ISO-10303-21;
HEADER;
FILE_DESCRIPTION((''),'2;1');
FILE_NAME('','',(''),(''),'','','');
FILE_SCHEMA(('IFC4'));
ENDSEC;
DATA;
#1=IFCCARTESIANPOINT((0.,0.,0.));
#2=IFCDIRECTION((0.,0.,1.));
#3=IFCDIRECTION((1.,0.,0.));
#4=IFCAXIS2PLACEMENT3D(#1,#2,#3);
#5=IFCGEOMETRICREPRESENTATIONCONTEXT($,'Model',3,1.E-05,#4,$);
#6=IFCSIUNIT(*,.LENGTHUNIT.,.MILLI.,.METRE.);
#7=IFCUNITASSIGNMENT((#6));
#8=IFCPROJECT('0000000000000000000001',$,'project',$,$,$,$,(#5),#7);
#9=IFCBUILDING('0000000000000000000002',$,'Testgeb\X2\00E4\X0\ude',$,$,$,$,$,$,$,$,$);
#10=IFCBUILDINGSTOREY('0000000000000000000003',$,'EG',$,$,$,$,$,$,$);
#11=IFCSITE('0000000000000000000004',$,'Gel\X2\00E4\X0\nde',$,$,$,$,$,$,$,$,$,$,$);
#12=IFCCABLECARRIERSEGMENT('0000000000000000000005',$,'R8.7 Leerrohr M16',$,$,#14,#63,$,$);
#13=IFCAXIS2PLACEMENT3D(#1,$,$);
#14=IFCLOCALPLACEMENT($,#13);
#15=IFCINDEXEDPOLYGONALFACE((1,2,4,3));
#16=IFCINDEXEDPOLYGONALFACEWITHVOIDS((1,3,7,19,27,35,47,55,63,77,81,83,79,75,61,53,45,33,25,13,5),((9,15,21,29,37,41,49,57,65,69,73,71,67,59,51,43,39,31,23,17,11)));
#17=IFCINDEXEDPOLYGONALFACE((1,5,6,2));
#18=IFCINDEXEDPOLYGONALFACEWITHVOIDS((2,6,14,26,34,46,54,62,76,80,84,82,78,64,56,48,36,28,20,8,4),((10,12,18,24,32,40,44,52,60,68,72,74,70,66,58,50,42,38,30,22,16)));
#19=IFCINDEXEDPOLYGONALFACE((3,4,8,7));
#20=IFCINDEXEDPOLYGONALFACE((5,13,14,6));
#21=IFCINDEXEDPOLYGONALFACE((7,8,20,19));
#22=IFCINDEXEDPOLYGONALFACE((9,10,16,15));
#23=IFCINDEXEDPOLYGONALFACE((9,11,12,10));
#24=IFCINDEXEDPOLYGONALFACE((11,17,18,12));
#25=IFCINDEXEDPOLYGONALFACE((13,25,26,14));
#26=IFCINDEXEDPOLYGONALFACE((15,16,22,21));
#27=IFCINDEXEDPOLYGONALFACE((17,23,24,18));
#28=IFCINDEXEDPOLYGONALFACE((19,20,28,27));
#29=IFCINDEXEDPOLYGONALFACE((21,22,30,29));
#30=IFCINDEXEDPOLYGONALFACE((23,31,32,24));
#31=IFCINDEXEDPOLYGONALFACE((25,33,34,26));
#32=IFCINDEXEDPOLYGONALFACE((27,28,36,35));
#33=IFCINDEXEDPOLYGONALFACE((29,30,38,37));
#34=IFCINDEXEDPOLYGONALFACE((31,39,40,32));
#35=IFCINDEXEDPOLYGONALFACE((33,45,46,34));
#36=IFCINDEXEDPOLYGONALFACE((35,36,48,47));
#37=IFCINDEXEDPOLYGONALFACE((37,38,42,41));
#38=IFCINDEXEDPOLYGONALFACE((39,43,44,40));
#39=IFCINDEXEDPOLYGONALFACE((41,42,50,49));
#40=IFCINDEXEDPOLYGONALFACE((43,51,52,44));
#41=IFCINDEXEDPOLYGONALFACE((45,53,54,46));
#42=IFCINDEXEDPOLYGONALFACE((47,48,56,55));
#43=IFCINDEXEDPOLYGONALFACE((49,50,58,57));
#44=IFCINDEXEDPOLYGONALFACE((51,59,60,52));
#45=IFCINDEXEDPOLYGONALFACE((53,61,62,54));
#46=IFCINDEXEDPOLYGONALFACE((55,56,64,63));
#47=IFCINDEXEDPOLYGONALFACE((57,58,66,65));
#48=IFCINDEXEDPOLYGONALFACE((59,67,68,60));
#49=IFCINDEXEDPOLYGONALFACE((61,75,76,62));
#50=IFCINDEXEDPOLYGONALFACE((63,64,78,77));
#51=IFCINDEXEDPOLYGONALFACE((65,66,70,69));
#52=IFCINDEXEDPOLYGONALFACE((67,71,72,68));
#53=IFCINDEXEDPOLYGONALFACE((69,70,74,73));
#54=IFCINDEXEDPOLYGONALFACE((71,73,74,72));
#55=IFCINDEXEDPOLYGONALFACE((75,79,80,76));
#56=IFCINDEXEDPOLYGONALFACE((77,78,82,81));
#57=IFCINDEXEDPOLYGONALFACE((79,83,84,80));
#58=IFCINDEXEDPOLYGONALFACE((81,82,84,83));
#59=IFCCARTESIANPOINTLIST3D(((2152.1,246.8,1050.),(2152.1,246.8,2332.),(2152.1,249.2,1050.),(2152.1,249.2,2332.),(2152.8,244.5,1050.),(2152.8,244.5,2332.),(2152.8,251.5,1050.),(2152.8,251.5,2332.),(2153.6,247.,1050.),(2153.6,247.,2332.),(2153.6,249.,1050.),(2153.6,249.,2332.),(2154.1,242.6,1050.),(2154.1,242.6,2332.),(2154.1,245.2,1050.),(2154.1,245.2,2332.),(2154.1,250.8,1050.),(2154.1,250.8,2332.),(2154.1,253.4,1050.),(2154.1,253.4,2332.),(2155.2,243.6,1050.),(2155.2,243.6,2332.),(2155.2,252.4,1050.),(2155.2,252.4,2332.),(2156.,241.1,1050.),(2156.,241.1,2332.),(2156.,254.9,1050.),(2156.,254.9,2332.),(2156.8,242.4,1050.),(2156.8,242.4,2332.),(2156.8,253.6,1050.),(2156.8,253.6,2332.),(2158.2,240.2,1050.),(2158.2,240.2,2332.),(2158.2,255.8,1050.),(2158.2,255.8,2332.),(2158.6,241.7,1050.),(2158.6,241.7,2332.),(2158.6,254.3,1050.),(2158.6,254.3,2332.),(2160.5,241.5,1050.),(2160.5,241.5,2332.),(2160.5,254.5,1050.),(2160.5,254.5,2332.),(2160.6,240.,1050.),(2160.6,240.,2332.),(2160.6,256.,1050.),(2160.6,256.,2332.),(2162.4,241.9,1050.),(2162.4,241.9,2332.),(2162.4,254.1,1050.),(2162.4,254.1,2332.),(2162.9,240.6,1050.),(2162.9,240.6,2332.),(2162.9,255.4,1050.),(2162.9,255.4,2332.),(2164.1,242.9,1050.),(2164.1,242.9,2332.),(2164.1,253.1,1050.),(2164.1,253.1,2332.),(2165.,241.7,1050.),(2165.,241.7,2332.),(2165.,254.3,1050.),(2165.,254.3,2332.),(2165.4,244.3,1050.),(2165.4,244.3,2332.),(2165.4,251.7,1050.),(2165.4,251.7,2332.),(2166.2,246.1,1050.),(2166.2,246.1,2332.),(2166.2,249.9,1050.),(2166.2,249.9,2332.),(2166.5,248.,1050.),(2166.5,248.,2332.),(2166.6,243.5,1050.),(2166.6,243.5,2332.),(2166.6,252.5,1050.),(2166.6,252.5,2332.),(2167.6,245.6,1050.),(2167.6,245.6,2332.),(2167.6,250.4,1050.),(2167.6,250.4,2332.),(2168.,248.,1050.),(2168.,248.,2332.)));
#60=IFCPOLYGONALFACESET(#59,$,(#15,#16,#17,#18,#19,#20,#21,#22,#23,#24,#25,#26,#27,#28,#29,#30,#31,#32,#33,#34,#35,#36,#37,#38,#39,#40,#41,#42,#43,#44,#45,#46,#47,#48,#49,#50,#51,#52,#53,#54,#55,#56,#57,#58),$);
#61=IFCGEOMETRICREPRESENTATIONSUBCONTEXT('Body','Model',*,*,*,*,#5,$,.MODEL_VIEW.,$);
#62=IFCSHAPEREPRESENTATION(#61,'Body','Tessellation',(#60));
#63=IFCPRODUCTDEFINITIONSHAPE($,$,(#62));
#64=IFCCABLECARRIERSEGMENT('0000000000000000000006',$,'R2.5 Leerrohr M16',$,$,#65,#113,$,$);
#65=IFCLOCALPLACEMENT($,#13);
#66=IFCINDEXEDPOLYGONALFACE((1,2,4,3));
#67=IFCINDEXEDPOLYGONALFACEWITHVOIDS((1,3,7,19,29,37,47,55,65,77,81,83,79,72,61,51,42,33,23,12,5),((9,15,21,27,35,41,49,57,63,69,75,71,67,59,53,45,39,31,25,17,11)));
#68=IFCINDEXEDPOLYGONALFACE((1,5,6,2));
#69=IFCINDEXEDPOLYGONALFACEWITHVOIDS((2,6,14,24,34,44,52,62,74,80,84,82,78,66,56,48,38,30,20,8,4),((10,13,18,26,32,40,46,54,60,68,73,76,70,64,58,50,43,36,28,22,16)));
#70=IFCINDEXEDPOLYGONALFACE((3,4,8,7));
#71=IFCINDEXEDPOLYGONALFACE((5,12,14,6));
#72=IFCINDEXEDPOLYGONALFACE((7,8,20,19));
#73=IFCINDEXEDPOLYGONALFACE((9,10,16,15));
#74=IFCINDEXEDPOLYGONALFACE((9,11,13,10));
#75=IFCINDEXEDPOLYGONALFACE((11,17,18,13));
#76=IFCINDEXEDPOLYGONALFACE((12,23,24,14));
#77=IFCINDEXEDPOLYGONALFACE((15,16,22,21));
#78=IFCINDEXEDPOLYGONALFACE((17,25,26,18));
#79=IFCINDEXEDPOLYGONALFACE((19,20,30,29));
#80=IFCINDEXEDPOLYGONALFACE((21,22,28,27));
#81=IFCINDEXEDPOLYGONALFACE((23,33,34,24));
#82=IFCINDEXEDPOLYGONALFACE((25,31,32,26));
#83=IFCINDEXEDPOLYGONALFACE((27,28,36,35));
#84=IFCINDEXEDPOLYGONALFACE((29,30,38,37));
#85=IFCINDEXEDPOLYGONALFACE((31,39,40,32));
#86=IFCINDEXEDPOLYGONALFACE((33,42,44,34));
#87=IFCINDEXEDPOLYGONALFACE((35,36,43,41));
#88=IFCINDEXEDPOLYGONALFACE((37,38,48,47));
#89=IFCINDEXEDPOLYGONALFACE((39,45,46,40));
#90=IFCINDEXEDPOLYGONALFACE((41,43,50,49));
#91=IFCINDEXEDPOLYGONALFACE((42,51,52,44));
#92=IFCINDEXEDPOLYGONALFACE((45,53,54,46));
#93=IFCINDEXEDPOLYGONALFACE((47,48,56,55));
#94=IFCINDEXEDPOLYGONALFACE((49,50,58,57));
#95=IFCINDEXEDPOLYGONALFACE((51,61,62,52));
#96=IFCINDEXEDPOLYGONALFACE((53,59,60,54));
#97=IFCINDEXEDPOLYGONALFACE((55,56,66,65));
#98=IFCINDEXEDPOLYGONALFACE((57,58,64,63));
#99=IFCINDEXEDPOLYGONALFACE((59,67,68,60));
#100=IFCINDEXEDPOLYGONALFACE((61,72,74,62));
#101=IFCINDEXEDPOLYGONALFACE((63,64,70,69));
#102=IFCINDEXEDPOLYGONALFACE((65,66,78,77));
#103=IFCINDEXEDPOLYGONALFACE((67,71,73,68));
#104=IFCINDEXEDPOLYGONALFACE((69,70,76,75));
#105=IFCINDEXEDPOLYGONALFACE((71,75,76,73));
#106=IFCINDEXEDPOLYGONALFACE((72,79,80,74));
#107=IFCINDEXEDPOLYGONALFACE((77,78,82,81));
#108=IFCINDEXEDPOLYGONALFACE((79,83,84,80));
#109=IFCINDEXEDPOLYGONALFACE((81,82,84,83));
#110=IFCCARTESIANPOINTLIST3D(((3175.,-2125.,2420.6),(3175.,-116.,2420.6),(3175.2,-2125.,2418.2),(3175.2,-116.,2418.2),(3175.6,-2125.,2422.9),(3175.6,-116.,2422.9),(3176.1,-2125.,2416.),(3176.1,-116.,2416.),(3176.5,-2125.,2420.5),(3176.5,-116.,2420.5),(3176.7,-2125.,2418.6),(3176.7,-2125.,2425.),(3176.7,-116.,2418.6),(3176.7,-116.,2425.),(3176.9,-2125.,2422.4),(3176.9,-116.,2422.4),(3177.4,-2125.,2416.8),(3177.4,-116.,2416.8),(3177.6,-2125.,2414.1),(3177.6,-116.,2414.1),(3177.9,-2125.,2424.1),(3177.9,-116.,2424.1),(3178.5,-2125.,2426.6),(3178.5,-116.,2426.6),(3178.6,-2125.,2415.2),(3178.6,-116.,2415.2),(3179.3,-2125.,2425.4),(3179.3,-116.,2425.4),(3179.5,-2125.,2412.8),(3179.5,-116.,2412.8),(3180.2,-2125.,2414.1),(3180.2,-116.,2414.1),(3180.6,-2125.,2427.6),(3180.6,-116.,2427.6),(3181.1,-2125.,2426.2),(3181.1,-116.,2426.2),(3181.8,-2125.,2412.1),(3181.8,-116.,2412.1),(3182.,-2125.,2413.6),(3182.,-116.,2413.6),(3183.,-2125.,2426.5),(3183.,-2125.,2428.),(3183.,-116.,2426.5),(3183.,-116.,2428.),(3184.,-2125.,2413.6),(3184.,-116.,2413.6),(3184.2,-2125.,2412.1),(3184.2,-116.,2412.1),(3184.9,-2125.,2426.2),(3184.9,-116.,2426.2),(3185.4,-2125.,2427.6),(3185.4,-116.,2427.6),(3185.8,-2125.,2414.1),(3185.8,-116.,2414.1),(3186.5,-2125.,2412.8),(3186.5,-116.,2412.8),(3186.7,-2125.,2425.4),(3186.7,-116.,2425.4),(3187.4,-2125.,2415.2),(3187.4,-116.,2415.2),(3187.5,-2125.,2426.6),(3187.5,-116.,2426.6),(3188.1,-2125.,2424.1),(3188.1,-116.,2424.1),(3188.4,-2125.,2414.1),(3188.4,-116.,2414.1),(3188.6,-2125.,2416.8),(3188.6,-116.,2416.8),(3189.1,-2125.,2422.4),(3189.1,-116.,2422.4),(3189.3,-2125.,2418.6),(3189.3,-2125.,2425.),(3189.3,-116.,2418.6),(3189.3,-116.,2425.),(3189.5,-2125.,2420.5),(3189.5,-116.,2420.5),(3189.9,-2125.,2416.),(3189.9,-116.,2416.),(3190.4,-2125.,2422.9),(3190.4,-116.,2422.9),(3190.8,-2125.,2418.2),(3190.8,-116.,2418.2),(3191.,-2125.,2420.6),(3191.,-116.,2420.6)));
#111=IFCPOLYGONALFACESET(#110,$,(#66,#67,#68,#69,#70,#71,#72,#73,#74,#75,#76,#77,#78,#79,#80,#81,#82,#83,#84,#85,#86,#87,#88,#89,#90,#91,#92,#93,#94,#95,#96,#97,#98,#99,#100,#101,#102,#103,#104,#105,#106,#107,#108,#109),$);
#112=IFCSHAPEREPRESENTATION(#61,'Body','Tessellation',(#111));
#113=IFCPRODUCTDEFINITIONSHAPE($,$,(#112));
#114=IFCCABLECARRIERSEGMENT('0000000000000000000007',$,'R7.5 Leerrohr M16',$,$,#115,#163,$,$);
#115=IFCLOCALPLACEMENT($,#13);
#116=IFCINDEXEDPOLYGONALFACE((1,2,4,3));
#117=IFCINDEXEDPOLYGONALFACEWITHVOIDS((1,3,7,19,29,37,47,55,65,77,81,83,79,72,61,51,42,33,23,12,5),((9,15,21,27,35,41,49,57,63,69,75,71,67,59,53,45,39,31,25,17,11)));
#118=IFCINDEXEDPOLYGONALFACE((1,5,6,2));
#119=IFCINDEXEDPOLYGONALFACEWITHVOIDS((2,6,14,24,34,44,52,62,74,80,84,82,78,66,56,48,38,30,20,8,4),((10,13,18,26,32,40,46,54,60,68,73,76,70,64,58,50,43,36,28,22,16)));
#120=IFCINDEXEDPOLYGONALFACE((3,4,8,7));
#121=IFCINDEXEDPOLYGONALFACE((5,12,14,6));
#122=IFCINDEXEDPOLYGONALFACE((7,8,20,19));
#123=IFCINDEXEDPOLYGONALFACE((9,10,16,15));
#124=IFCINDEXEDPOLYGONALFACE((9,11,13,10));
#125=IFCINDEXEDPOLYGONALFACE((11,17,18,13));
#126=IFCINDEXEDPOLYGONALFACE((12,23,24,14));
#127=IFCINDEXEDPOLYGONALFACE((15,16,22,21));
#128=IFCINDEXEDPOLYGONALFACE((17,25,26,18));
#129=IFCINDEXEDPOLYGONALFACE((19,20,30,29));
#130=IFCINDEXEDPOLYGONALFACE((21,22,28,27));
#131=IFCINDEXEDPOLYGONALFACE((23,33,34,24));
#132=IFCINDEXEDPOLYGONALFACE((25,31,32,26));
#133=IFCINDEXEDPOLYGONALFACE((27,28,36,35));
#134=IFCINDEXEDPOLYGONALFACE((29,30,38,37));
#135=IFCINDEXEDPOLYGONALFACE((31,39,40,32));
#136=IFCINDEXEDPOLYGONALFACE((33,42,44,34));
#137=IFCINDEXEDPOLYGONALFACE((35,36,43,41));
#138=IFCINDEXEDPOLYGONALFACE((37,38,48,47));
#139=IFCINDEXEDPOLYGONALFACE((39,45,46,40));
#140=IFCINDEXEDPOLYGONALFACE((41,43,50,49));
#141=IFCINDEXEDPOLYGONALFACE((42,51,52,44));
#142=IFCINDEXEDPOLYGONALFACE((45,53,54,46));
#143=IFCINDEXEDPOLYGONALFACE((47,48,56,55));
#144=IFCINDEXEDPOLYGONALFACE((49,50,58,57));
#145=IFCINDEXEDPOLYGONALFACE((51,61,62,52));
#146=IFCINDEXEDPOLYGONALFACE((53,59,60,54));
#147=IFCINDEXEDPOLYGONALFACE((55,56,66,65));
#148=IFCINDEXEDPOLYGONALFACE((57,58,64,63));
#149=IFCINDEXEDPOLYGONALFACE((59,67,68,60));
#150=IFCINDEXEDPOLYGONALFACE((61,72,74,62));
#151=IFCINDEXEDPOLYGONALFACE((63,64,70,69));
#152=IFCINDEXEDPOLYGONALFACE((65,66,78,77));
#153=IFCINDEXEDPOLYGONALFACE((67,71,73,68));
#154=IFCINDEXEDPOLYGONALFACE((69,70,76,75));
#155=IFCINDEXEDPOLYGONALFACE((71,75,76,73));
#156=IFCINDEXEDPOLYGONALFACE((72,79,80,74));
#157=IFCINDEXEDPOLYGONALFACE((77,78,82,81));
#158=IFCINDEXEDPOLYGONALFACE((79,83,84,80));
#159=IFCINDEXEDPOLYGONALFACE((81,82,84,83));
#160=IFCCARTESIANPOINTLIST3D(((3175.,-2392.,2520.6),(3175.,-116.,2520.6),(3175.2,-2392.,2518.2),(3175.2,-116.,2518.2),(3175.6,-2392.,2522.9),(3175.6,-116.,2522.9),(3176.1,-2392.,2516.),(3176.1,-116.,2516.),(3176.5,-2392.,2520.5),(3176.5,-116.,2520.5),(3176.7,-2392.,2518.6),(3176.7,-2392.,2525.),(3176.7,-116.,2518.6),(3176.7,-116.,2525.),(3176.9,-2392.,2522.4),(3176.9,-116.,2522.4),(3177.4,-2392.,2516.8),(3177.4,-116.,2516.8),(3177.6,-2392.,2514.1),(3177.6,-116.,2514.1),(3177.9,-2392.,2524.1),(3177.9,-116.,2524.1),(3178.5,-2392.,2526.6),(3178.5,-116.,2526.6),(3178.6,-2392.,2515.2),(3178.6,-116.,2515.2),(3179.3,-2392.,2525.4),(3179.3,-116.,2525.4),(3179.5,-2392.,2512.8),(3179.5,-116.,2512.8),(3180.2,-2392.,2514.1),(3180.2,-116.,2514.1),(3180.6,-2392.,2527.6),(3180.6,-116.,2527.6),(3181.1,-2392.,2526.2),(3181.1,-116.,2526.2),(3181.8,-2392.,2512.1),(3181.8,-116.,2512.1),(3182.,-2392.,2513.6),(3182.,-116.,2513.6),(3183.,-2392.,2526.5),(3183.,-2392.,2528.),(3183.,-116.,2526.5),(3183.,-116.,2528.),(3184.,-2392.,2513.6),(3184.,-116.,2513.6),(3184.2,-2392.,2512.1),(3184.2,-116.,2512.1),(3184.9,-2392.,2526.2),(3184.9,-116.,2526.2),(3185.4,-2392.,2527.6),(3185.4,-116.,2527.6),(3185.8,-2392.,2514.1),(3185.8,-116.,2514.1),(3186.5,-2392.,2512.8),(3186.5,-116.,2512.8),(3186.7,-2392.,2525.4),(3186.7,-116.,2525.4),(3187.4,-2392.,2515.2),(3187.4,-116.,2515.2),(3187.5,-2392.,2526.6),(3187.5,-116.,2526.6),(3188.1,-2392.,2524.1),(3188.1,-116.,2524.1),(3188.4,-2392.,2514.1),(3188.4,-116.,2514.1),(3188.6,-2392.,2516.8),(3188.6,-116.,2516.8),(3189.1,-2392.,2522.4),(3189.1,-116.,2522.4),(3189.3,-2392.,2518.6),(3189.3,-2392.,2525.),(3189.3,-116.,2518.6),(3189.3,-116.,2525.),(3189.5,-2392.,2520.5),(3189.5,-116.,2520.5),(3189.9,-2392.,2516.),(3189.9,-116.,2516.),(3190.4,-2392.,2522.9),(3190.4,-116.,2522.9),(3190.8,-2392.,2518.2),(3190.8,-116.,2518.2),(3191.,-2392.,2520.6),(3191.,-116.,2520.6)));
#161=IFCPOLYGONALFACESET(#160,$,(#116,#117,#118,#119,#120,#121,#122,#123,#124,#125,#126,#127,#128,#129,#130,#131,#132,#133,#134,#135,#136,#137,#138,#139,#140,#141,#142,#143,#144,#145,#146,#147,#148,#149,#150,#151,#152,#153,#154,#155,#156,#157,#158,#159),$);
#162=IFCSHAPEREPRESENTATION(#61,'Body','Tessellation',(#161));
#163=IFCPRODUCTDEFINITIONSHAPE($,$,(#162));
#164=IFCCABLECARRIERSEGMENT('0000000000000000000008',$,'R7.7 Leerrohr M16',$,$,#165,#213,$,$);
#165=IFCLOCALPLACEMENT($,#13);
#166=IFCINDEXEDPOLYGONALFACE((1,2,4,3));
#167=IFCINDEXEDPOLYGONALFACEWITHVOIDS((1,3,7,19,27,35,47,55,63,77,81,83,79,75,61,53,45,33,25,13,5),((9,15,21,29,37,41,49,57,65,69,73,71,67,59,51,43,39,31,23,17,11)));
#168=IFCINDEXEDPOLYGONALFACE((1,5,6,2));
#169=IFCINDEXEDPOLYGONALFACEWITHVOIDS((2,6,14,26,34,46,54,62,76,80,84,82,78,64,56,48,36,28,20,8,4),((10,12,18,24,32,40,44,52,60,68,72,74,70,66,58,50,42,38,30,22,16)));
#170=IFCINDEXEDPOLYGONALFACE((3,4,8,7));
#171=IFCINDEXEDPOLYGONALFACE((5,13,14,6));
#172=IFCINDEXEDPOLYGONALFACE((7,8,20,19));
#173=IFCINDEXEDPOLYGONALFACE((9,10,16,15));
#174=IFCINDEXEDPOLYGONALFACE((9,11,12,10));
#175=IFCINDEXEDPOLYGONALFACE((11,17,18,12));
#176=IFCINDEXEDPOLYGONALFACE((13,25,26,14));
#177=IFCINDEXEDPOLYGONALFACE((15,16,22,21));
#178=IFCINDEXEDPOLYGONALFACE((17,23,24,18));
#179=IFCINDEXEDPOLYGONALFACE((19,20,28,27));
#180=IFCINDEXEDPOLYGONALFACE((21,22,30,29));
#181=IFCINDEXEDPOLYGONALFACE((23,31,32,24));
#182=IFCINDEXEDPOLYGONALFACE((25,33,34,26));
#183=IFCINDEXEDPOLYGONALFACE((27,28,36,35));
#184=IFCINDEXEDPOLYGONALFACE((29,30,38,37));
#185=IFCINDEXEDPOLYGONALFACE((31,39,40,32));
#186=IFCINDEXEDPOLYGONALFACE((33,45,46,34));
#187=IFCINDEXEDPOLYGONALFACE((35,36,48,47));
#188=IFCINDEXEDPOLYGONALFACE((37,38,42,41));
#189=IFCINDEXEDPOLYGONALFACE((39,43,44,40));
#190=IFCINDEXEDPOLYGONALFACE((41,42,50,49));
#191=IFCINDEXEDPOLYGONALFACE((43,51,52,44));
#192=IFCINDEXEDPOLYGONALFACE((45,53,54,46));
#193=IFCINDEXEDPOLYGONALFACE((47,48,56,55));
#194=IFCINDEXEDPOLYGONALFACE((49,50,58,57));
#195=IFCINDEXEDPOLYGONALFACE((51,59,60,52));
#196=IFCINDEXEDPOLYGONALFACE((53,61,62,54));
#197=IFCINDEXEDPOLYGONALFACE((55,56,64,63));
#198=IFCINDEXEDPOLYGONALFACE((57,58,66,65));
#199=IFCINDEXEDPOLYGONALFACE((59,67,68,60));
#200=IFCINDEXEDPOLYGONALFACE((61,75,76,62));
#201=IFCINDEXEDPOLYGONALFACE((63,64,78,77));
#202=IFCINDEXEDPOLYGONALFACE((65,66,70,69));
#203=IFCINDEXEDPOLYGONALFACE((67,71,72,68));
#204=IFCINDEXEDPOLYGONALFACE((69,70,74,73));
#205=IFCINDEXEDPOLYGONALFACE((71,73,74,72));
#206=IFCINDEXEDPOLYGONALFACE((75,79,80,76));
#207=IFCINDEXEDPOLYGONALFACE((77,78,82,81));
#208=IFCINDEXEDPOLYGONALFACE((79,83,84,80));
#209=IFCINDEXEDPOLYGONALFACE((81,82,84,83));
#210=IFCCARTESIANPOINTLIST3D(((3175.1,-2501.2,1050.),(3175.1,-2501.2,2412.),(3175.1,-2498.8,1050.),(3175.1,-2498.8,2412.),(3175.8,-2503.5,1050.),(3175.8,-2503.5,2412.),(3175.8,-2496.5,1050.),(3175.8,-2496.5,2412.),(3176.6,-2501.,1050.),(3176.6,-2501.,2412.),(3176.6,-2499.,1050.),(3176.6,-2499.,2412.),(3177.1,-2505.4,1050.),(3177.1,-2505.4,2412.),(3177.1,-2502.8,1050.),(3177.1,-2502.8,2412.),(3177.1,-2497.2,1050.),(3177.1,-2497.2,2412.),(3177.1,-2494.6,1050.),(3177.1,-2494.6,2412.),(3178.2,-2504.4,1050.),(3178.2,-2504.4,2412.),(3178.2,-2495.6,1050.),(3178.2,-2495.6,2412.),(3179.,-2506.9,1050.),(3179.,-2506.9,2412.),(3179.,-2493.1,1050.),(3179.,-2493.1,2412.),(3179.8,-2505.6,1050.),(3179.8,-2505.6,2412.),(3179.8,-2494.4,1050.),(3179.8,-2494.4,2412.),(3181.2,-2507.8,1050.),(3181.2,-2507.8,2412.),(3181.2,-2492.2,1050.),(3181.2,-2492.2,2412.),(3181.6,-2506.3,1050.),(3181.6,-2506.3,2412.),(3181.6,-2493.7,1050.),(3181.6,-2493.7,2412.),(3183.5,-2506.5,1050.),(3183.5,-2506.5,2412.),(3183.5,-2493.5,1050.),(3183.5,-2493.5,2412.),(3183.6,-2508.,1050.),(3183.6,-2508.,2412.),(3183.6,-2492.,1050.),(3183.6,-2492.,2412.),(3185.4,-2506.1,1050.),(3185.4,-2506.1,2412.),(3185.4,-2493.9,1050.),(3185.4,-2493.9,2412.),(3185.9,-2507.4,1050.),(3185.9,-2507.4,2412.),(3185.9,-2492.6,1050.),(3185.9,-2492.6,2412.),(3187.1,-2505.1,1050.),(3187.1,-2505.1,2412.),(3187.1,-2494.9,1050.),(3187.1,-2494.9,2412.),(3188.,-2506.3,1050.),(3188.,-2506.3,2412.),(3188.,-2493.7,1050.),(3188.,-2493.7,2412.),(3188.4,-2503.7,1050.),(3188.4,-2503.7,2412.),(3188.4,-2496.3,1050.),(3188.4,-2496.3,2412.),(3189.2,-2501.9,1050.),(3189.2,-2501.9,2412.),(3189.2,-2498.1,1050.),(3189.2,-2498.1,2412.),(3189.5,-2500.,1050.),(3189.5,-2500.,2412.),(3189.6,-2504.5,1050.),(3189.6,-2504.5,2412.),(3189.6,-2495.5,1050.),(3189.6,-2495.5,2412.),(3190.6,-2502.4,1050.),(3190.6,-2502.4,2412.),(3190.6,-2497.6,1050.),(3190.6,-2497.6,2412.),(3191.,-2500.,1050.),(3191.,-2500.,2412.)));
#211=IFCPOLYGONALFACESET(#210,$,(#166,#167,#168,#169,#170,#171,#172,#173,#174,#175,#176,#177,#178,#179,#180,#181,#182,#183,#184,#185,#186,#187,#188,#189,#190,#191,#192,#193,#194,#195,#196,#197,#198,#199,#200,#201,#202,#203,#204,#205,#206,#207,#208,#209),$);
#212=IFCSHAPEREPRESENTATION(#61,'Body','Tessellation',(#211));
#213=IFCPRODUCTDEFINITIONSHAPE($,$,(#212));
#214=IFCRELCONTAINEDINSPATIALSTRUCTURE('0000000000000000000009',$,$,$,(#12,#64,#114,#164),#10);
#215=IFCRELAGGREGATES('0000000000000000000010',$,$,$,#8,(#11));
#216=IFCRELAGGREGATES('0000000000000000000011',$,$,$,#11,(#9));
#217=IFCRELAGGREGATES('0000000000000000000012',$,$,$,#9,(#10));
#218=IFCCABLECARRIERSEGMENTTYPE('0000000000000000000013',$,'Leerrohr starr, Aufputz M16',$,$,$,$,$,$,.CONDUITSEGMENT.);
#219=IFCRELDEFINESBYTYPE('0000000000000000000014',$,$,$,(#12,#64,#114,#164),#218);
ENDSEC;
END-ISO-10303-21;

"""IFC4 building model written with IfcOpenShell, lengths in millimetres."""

from ifc_helpers import new_model, si_unit, frame, origin_with_axes, place, context, subcontext, project, spatial, hollow_circle, extrude, type_object, element, save


model = new_model("IFC4")

# Units and contexts
model_context = context("Model", 3, precision=1e-05, world=origin_with_axes())
body_context = subcontext(model_context, "Body", "Model", "MODEL_VIEW")
ifc_project = project(units=[si_unit("LENGTHUNIT", "METRE", prefix="MILLI")], contexts=[model_context])

# Site, building, storey
site = spatial("IfcSite", under=ifc_project, Name="Gelände")
building = spatial("IfcBuilding", under=site, Name="Testgebäude")
storey = spatial("IfcBuildingStorey", under=building, Name="EG")

# Cable carrier segments
cable_carrier_segment_type_1 = type_object("IfcCableCarrierSegmentType", Name="Leerrohr starr, Aufputz M16", PredefinedType="CONDUITSEGMENT")
cable_carrier_segment_1_placement = place(None, frame((2160.0, 248.0, 2332.0), z_axis=(0.0, 0.0, -1.0), x_axis=(1.0, 0.0, 0.0)))
element("IfcCableCarrierSegment", 1, at=cable_carrier_segment_1_placement, inside=storey, type_object=cable_carrier_segment_type_1, Name="R8.7 Leerrohr M16", context=body_context, shape_type="SweptSolid", body=[
    extrude(hollow_circle(Radius=8.0, WallThickness=1.5), None, (0.0, 0.0, 1.0), 1282.0),
])
cable_carrier_segment_2_placement = place(None, frame((3183.0, -116.0, 2420.0), z_axis=(0.0, -1.0, 0.0), x_axis=(0.0, 0.0, 1.0)))
element("IfcCableCarrierSegment", 2, at=cable_carrier_segment_2_placement, inside=storey, type_object=cable_carrier_segment_type_1, Name="R2.5 Leerrohr M16", context=body_context, shape_type="SweptSolid", body=[
    extrude(hollow_circle(Radius=8.0, WallThickness=1.5), None, (0.0, 0.0, 1.0), 2009.0),
])
cable_carrier_segment_3_placement = place(None, frame((3183.0, -116.0, 2520.0), z_axis=(0.0, -1.0, 0.0), x_axis=(0.0, 0.0, 1.0)))
element("IfcCableCarrierSegment", 3, at=cable_carrier_segment_3_placement, inside=storey, type_object=cable_carrier_segment_type_1, Name="R7.5 Leerrohr M16", context=body_context, shape_type="SweptSolid", body=[
    extrude(hollow_circle(Radius=8.0, WallThickness=1.5), None, (0.0, 0.0, 1.0), 2276.0),
])
cable_carrier_segment_4_placement = place(None, frame((3183.0, -2500.0, 2412.0), z_axis=(0.0, 0.0, -1.0), x_axis=(1.0, 0.0, 0.0)))
element("IfcCableCarrierSegment", 4, at=cable_carrier_segment_4_placement, inside=storey, type_object=cable_carrier_segment_type_1, Name="R7.7 Leerrohr M16", context=body_context, shape_type="SweptSolid", body=[
    extrude(hollow_circle(Radius=8.0, WallThickness=1.5), None, (0.0, 0.0, 1.0), 1362.0),
])

save(model, "model.ifc")
